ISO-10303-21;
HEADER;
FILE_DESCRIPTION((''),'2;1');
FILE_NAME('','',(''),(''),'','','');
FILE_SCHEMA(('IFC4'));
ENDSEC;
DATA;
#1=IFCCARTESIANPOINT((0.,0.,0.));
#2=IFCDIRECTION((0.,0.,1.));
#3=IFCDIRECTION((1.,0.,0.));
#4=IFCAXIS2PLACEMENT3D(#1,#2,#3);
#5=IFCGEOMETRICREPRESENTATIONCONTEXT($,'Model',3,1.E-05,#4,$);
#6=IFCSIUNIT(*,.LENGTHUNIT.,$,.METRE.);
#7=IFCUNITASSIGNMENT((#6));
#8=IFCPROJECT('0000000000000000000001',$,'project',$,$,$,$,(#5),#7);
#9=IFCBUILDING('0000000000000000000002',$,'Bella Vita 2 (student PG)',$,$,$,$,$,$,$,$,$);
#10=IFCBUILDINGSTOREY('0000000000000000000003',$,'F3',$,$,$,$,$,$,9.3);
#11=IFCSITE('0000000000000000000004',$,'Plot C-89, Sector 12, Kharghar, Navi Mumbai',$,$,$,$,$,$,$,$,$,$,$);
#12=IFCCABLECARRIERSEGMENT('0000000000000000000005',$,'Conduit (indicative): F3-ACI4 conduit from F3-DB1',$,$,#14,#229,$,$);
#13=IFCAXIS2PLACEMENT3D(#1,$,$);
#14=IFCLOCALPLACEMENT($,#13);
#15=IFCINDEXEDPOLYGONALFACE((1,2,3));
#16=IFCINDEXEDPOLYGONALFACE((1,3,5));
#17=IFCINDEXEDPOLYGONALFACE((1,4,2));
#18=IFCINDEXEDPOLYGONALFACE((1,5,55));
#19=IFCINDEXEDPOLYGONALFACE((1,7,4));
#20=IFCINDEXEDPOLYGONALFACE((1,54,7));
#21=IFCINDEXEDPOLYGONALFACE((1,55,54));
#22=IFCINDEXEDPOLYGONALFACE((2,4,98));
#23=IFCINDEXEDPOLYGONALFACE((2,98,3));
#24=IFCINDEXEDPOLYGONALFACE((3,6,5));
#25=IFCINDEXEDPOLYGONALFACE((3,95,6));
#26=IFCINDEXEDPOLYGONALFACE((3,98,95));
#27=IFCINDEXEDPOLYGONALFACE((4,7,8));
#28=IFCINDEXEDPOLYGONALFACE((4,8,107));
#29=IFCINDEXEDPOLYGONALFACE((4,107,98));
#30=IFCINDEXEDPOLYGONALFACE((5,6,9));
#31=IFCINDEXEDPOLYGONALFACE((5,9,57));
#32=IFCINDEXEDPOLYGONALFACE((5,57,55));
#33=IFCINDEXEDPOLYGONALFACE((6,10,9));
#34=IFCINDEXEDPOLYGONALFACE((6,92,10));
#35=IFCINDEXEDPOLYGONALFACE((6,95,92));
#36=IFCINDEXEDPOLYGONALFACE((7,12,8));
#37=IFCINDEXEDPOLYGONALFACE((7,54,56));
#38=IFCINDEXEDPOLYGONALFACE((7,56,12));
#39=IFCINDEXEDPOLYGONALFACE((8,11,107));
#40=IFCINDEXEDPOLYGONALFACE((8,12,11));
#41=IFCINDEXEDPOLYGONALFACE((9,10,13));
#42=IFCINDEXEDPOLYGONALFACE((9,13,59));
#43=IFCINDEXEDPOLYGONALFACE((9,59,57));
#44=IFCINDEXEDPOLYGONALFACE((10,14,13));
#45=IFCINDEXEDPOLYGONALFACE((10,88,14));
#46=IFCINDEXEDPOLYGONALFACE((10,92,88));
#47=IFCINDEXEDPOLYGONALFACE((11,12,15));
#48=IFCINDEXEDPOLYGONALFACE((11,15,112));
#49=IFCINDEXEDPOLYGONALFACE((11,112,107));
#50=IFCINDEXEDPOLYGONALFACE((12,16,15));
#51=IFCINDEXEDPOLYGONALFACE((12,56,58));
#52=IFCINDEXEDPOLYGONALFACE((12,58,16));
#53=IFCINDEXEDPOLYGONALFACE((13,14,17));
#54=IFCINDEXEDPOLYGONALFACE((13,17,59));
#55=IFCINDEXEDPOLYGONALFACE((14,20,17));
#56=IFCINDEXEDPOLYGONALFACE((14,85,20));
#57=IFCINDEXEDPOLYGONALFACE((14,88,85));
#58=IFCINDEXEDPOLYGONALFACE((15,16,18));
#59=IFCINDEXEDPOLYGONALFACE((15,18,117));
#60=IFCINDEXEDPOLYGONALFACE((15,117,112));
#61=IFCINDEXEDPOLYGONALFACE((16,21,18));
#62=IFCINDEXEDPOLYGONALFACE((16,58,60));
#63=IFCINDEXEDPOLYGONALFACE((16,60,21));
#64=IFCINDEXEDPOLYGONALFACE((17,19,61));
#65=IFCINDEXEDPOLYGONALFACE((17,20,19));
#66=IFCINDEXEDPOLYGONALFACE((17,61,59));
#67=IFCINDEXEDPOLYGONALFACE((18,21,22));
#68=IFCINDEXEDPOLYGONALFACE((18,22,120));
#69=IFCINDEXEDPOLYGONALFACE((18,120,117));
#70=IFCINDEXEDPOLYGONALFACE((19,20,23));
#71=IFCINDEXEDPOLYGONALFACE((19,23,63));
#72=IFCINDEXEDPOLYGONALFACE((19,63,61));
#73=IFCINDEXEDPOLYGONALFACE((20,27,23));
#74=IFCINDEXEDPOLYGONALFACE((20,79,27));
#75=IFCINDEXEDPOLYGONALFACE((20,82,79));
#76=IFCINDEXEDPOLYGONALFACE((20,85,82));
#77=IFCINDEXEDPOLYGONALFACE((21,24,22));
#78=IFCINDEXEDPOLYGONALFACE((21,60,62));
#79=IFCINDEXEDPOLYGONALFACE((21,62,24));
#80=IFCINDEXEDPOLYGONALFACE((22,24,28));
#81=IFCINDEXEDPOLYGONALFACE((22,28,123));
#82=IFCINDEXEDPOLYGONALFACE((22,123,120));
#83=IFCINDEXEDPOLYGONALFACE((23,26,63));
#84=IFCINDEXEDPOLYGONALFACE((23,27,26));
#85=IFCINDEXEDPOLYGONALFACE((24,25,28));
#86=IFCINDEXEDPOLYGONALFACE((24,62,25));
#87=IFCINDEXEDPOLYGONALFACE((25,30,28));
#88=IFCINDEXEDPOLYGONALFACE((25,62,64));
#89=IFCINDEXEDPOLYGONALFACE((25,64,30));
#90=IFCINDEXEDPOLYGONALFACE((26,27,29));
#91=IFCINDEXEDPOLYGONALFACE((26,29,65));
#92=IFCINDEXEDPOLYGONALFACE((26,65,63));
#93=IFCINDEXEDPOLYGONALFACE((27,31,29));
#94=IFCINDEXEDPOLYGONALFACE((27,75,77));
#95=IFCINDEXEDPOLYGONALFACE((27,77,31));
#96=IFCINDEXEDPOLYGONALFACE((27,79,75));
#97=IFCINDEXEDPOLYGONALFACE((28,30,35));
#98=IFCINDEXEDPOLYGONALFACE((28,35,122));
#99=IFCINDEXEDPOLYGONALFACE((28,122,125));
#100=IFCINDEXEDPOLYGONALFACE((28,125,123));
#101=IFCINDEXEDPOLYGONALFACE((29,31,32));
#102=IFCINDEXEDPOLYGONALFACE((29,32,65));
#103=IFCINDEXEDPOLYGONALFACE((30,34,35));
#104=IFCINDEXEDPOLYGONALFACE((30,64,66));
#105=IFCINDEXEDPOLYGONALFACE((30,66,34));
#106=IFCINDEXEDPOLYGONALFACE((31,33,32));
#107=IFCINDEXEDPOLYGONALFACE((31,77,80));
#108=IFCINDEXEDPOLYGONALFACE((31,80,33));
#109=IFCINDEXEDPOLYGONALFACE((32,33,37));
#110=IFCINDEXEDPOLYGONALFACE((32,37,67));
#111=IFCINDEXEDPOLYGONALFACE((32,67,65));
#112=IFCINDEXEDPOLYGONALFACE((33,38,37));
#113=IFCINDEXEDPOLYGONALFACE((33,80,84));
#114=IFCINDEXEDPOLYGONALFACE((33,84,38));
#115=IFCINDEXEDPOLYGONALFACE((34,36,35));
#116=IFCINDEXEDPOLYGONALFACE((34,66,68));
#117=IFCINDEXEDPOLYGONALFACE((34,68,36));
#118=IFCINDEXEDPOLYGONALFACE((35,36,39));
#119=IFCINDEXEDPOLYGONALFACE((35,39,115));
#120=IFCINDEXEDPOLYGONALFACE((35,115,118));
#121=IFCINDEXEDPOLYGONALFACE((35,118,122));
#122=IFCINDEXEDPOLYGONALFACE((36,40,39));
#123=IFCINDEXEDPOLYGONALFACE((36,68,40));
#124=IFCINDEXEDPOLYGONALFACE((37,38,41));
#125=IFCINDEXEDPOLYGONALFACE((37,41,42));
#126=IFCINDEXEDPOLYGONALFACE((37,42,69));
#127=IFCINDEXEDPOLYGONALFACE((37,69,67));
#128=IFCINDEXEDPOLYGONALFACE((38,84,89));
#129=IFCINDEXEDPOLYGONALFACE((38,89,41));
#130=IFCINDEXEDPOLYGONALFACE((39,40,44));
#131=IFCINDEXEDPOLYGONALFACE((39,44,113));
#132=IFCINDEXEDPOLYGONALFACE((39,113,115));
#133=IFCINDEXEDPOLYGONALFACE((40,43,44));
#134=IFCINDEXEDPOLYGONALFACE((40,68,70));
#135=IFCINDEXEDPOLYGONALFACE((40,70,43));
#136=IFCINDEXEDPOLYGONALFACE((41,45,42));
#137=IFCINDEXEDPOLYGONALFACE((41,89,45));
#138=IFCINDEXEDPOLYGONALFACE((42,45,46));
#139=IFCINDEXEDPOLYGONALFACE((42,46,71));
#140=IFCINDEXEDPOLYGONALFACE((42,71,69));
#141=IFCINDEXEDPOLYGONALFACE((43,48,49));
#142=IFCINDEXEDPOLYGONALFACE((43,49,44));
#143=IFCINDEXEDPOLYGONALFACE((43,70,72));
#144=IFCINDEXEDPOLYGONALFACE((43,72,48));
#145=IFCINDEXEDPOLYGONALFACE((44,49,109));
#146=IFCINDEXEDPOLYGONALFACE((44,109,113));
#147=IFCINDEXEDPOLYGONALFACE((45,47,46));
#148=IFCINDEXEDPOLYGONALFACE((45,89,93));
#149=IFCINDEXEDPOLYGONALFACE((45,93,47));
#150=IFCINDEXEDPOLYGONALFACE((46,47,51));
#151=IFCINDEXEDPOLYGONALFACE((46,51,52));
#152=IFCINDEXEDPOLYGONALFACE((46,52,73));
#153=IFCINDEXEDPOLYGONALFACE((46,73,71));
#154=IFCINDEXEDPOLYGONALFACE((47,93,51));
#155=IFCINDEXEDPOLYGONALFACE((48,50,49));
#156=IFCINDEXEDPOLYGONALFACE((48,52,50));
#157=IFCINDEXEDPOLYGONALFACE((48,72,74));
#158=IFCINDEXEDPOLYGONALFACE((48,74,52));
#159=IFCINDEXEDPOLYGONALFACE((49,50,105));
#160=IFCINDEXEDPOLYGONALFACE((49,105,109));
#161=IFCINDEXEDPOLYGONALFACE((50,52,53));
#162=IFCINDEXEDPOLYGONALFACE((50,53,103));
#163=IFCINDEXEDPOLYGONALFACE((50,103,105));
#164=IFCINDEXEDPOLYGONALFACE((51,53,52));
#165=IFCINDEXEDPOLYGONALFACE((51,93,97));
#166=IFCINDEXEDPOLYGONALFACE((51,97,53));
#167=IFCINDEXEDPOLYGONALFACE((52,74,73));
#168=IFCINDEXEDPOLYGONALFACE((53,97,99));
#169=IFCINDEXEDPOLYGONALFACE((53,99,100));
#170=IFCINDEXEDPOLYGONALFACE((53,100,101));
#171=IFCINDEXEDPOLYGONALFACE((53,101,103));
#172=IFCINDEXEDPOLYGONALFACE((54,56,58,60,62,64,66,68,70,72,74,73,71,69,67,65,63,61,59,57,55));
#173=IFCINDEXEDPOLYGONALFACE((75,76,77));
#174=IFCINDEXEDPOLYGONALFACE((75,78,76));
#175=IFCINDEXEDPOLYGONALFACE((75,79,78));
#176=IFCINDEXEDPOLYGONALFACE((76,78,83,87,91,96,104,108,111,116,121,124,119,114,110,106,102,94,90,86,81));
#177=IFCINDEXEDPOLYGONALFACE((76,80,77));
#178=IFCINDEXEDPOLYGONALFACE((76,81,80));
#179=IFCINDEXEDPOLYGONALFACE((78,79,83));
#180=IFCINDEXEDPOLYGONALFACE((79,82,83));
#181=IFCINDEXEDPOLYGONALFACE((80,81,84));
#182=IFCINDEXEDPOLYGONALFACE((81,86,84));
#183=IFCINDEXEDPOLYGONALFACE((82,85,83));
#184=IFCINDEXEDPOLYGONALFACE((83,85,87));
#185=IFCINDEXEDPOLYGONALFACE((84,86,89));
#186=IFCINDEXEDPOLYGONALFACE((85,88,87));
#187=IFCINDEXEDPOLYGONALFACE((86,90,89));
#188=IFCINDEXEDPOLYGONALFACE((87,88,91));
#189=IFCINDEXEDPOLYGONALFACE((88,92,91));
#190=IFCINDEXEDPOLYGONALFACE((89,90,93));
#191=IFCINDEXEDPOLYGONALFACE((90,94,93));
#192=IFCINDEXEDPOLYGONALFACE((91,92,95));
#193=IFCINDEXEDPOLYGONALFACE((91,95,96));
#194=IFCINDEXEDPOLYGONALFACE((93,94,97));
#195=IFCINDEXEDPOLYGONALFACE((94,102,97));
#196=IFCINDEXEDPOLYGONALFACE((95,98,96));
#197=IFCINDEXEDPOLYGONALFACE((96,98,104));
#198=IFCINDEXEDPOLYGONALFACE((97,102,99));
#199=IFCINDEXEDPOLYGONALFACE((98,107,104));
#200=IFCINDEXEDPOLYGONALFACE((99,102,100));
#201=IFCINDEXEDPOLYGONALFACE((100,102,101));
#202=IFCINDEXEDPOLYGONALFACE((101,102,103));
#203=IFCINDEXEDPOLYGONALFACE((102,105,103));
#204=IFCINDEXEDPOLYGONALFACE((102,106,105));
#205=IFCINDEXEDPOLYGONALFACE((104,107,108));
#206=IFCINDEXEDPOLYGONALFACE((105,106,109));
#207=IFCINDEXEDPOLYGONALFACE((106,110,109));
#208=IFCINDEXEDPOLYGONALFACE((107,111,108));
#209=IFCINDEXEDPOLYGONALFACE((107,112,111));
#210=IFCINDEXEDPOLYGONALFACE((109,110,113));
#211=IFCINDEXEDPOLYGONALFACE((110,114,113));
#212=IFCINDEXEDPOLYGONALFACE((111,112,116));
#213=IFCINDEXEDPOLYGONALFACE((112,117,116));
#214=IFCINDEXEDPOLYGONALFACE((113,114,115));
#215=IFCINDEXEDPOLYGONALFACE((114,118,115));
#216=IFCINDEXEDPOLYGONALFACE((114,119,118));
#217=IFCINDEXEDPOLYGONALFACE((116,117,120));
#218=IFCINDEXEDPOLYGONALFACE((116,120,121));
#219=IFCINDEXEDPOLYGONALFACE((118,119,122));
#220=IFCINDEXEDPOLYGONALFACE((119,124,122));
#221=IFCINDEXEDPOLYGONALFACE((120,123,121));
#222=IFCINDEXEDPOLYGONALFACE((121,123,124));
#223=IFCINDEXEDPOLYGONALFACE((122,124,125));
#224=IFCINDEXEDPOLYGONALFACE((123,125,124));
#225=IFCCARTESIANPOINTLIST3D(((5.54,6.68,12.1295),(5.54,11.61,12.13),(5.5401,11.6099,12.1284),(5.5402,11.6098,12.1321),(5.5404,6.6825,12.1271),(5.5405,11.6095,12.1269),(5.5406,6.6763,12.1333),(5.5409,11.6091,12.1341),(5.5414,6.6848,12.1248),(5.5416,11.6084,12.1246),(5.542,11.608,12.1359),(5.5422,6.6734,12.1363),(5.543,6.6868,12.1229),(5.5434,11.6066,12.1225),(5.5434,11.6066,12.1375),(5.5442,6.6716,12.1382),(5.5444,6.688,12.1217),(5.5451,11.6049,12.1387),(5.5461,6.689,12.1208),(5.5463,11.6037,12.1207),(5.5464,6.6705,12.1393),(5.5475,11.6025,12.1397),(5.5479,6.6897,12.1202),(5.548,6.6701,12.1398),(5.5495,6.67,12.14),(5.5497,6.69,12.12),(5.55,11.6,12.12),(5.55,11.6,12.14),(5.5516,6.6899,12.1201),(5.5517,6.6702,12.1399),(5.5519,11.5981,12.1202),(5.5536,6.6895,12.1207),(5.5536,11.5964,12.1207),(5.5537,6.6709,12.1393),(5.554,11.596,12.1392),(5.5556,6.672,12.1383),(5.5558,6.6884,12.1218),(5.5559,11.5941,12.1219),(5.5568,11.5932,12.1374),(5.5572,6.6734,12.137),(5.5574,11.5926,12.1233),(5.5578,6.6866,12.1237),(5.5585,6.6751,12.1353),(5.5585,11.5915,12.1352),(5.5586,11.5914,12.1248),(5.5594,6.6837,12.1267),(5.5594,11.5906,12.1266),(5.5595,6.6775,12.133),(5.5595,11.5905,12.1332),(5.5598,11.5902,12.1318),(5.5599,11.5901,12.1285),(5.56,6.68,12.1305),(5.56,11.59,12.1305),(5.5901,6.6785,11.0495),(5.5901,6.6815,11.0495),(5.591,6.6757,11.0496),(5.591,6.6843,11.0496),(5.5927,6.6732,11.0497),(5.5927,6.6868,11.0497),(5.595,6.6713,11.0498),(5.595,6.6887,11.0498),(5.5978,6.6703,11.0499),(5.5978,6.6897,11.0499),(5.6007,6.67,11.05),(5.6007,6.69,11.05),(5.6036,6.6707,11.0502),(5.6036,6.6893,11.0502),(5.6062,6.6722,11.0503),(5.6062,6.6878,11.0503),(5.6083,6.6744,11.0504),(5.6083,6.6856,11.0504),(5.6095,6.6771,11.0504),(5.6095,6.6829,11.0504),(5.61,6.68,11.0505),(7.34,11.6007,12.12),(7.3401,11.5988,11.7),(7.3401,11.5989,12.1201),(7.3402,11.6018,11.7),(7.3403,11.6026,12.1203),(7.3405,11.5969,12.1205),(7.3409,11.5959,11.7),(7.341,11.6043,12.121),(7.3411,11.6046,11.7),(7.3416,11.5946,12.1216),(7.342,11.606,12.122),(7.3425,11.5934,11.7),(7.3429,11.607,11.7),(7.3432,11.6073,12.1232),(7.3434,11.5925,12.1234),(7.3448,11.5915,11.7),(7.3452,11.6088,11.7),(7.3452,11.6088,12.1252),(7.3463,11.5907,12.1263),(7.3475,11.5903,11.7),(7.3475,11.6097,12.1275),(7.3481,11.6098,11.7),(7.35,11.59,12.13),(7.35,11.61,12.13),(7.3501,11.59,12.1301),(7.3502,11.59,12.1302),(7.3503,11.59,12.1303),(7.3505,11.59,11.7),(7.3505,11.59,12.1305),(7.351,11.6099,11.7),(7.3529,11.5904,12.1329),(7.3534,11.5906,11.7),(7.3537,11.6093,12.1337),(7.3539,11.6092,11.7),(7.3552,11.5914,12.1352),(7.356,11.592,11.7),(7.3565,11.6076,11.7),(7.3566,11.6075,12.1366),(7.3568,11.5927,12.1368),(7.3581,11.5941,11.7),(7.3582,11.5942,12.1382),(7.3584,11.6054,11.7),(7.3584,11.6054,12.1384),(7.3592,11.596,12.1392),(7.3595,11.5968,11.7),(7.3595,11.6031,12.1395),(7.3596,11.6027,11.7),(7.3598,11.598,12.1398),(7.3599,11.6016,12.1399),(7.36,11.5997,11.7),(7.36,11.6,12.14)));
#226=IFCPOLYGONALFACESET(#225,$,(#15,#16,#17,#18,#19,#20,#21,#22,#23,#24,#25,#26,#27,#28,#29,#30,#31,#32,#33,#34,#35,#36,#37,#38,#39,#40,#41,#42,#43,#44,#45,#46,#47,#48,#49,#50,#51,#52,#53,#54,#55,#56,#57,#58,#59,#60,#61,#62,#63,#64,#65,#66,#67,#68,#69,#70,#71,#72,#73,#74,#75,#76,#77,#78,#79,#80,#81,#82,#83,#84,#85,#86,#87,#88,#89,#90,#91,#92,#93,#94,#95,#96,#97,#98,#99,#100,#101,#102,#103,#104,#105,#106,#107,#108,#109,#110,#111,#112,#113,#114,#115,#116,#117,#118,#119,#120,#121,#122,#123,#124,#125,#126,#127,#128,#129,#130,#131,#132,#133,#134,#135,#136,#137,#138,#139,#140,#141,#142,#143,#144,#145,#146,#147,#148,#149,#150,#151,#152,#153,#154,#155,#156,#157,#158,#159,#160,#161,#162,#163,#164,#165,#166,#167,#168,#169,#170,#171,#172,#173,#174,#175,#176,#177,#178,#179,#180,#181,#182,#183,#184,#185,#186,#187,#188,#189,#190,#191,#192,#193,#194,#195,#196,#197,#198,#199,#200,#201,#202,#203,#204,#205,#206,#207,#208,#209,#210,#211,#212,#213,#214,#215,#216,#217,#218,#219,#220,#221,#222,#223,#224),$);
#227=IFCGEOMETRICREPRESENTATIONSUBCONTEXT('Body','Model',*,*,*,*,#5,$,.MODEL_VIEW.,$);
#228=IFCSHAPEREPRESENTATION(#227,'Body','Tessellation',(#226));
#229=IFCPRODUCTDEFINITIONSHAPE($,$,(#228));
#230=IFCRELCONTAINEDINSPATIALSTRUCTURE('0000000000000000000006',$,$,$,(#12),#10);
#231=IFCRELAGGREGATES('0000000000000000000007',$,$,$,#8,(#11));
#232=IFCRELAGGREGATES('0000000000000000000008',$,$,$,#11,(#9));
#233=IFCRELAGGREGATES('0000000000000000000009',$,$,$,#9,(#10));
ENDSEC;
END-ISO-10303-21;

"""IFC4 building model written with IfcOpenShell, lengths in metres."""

from ifc_helpers import new_model, entity, si_unit, origin, origin_with_axes, place, context, subcontext, project, spatial, element, save


model = new_model("IFC4")

# Units and contexts
model_context = context("Model", 3, precision=1e-05, world=origin_with_axes())
body_context = subcontext(model_context, "Body", "Model", "MODEL_VIEW")
ifc_project = project(units=[si_unit("LENGTHUNIT", "METRE")], contexts=[model_context])

# Site, building, storey
site = spatial("IfcSite", under=ifc_project, Name="Plot C-89, Sector 12, Kharghar, Navi Mumbai")
building = spatial("IfcBuilding", under=site, Name="Bella Vita 2 (student PG)")
storey = spatial("IfcBuildingStorey", under=building, Name="F3", Elevation=9.3)

# Cable carrier segment
cable_carrier_segment_1_placement = place(None, origin())
element("IfcCableCarrierSegment", 1, at=cable_carrier_segment_1_placement, inside=storey, Name="Conduit (indicative): F3-ACI4 conduit from F3-DB1", context=body_context, shape_type="AdvancedSweptSolid", body=[
    entity("IfcSweptDiskSolid", entity("IfcPolyline", [entity("IfcCartesianPoint", [5.6, 6.68, 11.05]), entity("IfcCartesianPoint", [5.55, 6.68, 12.13]), entity("IfcCartesianPoint", [5.55, 11.6, 12.13]), entity("IfcCartesianPoint", [7.35, 11.6, 12.13]), entity("IfcCartesianPoint", [7.35, 11.6, 11.7])]), 0.01),
])

save(model, "model.ifc")
